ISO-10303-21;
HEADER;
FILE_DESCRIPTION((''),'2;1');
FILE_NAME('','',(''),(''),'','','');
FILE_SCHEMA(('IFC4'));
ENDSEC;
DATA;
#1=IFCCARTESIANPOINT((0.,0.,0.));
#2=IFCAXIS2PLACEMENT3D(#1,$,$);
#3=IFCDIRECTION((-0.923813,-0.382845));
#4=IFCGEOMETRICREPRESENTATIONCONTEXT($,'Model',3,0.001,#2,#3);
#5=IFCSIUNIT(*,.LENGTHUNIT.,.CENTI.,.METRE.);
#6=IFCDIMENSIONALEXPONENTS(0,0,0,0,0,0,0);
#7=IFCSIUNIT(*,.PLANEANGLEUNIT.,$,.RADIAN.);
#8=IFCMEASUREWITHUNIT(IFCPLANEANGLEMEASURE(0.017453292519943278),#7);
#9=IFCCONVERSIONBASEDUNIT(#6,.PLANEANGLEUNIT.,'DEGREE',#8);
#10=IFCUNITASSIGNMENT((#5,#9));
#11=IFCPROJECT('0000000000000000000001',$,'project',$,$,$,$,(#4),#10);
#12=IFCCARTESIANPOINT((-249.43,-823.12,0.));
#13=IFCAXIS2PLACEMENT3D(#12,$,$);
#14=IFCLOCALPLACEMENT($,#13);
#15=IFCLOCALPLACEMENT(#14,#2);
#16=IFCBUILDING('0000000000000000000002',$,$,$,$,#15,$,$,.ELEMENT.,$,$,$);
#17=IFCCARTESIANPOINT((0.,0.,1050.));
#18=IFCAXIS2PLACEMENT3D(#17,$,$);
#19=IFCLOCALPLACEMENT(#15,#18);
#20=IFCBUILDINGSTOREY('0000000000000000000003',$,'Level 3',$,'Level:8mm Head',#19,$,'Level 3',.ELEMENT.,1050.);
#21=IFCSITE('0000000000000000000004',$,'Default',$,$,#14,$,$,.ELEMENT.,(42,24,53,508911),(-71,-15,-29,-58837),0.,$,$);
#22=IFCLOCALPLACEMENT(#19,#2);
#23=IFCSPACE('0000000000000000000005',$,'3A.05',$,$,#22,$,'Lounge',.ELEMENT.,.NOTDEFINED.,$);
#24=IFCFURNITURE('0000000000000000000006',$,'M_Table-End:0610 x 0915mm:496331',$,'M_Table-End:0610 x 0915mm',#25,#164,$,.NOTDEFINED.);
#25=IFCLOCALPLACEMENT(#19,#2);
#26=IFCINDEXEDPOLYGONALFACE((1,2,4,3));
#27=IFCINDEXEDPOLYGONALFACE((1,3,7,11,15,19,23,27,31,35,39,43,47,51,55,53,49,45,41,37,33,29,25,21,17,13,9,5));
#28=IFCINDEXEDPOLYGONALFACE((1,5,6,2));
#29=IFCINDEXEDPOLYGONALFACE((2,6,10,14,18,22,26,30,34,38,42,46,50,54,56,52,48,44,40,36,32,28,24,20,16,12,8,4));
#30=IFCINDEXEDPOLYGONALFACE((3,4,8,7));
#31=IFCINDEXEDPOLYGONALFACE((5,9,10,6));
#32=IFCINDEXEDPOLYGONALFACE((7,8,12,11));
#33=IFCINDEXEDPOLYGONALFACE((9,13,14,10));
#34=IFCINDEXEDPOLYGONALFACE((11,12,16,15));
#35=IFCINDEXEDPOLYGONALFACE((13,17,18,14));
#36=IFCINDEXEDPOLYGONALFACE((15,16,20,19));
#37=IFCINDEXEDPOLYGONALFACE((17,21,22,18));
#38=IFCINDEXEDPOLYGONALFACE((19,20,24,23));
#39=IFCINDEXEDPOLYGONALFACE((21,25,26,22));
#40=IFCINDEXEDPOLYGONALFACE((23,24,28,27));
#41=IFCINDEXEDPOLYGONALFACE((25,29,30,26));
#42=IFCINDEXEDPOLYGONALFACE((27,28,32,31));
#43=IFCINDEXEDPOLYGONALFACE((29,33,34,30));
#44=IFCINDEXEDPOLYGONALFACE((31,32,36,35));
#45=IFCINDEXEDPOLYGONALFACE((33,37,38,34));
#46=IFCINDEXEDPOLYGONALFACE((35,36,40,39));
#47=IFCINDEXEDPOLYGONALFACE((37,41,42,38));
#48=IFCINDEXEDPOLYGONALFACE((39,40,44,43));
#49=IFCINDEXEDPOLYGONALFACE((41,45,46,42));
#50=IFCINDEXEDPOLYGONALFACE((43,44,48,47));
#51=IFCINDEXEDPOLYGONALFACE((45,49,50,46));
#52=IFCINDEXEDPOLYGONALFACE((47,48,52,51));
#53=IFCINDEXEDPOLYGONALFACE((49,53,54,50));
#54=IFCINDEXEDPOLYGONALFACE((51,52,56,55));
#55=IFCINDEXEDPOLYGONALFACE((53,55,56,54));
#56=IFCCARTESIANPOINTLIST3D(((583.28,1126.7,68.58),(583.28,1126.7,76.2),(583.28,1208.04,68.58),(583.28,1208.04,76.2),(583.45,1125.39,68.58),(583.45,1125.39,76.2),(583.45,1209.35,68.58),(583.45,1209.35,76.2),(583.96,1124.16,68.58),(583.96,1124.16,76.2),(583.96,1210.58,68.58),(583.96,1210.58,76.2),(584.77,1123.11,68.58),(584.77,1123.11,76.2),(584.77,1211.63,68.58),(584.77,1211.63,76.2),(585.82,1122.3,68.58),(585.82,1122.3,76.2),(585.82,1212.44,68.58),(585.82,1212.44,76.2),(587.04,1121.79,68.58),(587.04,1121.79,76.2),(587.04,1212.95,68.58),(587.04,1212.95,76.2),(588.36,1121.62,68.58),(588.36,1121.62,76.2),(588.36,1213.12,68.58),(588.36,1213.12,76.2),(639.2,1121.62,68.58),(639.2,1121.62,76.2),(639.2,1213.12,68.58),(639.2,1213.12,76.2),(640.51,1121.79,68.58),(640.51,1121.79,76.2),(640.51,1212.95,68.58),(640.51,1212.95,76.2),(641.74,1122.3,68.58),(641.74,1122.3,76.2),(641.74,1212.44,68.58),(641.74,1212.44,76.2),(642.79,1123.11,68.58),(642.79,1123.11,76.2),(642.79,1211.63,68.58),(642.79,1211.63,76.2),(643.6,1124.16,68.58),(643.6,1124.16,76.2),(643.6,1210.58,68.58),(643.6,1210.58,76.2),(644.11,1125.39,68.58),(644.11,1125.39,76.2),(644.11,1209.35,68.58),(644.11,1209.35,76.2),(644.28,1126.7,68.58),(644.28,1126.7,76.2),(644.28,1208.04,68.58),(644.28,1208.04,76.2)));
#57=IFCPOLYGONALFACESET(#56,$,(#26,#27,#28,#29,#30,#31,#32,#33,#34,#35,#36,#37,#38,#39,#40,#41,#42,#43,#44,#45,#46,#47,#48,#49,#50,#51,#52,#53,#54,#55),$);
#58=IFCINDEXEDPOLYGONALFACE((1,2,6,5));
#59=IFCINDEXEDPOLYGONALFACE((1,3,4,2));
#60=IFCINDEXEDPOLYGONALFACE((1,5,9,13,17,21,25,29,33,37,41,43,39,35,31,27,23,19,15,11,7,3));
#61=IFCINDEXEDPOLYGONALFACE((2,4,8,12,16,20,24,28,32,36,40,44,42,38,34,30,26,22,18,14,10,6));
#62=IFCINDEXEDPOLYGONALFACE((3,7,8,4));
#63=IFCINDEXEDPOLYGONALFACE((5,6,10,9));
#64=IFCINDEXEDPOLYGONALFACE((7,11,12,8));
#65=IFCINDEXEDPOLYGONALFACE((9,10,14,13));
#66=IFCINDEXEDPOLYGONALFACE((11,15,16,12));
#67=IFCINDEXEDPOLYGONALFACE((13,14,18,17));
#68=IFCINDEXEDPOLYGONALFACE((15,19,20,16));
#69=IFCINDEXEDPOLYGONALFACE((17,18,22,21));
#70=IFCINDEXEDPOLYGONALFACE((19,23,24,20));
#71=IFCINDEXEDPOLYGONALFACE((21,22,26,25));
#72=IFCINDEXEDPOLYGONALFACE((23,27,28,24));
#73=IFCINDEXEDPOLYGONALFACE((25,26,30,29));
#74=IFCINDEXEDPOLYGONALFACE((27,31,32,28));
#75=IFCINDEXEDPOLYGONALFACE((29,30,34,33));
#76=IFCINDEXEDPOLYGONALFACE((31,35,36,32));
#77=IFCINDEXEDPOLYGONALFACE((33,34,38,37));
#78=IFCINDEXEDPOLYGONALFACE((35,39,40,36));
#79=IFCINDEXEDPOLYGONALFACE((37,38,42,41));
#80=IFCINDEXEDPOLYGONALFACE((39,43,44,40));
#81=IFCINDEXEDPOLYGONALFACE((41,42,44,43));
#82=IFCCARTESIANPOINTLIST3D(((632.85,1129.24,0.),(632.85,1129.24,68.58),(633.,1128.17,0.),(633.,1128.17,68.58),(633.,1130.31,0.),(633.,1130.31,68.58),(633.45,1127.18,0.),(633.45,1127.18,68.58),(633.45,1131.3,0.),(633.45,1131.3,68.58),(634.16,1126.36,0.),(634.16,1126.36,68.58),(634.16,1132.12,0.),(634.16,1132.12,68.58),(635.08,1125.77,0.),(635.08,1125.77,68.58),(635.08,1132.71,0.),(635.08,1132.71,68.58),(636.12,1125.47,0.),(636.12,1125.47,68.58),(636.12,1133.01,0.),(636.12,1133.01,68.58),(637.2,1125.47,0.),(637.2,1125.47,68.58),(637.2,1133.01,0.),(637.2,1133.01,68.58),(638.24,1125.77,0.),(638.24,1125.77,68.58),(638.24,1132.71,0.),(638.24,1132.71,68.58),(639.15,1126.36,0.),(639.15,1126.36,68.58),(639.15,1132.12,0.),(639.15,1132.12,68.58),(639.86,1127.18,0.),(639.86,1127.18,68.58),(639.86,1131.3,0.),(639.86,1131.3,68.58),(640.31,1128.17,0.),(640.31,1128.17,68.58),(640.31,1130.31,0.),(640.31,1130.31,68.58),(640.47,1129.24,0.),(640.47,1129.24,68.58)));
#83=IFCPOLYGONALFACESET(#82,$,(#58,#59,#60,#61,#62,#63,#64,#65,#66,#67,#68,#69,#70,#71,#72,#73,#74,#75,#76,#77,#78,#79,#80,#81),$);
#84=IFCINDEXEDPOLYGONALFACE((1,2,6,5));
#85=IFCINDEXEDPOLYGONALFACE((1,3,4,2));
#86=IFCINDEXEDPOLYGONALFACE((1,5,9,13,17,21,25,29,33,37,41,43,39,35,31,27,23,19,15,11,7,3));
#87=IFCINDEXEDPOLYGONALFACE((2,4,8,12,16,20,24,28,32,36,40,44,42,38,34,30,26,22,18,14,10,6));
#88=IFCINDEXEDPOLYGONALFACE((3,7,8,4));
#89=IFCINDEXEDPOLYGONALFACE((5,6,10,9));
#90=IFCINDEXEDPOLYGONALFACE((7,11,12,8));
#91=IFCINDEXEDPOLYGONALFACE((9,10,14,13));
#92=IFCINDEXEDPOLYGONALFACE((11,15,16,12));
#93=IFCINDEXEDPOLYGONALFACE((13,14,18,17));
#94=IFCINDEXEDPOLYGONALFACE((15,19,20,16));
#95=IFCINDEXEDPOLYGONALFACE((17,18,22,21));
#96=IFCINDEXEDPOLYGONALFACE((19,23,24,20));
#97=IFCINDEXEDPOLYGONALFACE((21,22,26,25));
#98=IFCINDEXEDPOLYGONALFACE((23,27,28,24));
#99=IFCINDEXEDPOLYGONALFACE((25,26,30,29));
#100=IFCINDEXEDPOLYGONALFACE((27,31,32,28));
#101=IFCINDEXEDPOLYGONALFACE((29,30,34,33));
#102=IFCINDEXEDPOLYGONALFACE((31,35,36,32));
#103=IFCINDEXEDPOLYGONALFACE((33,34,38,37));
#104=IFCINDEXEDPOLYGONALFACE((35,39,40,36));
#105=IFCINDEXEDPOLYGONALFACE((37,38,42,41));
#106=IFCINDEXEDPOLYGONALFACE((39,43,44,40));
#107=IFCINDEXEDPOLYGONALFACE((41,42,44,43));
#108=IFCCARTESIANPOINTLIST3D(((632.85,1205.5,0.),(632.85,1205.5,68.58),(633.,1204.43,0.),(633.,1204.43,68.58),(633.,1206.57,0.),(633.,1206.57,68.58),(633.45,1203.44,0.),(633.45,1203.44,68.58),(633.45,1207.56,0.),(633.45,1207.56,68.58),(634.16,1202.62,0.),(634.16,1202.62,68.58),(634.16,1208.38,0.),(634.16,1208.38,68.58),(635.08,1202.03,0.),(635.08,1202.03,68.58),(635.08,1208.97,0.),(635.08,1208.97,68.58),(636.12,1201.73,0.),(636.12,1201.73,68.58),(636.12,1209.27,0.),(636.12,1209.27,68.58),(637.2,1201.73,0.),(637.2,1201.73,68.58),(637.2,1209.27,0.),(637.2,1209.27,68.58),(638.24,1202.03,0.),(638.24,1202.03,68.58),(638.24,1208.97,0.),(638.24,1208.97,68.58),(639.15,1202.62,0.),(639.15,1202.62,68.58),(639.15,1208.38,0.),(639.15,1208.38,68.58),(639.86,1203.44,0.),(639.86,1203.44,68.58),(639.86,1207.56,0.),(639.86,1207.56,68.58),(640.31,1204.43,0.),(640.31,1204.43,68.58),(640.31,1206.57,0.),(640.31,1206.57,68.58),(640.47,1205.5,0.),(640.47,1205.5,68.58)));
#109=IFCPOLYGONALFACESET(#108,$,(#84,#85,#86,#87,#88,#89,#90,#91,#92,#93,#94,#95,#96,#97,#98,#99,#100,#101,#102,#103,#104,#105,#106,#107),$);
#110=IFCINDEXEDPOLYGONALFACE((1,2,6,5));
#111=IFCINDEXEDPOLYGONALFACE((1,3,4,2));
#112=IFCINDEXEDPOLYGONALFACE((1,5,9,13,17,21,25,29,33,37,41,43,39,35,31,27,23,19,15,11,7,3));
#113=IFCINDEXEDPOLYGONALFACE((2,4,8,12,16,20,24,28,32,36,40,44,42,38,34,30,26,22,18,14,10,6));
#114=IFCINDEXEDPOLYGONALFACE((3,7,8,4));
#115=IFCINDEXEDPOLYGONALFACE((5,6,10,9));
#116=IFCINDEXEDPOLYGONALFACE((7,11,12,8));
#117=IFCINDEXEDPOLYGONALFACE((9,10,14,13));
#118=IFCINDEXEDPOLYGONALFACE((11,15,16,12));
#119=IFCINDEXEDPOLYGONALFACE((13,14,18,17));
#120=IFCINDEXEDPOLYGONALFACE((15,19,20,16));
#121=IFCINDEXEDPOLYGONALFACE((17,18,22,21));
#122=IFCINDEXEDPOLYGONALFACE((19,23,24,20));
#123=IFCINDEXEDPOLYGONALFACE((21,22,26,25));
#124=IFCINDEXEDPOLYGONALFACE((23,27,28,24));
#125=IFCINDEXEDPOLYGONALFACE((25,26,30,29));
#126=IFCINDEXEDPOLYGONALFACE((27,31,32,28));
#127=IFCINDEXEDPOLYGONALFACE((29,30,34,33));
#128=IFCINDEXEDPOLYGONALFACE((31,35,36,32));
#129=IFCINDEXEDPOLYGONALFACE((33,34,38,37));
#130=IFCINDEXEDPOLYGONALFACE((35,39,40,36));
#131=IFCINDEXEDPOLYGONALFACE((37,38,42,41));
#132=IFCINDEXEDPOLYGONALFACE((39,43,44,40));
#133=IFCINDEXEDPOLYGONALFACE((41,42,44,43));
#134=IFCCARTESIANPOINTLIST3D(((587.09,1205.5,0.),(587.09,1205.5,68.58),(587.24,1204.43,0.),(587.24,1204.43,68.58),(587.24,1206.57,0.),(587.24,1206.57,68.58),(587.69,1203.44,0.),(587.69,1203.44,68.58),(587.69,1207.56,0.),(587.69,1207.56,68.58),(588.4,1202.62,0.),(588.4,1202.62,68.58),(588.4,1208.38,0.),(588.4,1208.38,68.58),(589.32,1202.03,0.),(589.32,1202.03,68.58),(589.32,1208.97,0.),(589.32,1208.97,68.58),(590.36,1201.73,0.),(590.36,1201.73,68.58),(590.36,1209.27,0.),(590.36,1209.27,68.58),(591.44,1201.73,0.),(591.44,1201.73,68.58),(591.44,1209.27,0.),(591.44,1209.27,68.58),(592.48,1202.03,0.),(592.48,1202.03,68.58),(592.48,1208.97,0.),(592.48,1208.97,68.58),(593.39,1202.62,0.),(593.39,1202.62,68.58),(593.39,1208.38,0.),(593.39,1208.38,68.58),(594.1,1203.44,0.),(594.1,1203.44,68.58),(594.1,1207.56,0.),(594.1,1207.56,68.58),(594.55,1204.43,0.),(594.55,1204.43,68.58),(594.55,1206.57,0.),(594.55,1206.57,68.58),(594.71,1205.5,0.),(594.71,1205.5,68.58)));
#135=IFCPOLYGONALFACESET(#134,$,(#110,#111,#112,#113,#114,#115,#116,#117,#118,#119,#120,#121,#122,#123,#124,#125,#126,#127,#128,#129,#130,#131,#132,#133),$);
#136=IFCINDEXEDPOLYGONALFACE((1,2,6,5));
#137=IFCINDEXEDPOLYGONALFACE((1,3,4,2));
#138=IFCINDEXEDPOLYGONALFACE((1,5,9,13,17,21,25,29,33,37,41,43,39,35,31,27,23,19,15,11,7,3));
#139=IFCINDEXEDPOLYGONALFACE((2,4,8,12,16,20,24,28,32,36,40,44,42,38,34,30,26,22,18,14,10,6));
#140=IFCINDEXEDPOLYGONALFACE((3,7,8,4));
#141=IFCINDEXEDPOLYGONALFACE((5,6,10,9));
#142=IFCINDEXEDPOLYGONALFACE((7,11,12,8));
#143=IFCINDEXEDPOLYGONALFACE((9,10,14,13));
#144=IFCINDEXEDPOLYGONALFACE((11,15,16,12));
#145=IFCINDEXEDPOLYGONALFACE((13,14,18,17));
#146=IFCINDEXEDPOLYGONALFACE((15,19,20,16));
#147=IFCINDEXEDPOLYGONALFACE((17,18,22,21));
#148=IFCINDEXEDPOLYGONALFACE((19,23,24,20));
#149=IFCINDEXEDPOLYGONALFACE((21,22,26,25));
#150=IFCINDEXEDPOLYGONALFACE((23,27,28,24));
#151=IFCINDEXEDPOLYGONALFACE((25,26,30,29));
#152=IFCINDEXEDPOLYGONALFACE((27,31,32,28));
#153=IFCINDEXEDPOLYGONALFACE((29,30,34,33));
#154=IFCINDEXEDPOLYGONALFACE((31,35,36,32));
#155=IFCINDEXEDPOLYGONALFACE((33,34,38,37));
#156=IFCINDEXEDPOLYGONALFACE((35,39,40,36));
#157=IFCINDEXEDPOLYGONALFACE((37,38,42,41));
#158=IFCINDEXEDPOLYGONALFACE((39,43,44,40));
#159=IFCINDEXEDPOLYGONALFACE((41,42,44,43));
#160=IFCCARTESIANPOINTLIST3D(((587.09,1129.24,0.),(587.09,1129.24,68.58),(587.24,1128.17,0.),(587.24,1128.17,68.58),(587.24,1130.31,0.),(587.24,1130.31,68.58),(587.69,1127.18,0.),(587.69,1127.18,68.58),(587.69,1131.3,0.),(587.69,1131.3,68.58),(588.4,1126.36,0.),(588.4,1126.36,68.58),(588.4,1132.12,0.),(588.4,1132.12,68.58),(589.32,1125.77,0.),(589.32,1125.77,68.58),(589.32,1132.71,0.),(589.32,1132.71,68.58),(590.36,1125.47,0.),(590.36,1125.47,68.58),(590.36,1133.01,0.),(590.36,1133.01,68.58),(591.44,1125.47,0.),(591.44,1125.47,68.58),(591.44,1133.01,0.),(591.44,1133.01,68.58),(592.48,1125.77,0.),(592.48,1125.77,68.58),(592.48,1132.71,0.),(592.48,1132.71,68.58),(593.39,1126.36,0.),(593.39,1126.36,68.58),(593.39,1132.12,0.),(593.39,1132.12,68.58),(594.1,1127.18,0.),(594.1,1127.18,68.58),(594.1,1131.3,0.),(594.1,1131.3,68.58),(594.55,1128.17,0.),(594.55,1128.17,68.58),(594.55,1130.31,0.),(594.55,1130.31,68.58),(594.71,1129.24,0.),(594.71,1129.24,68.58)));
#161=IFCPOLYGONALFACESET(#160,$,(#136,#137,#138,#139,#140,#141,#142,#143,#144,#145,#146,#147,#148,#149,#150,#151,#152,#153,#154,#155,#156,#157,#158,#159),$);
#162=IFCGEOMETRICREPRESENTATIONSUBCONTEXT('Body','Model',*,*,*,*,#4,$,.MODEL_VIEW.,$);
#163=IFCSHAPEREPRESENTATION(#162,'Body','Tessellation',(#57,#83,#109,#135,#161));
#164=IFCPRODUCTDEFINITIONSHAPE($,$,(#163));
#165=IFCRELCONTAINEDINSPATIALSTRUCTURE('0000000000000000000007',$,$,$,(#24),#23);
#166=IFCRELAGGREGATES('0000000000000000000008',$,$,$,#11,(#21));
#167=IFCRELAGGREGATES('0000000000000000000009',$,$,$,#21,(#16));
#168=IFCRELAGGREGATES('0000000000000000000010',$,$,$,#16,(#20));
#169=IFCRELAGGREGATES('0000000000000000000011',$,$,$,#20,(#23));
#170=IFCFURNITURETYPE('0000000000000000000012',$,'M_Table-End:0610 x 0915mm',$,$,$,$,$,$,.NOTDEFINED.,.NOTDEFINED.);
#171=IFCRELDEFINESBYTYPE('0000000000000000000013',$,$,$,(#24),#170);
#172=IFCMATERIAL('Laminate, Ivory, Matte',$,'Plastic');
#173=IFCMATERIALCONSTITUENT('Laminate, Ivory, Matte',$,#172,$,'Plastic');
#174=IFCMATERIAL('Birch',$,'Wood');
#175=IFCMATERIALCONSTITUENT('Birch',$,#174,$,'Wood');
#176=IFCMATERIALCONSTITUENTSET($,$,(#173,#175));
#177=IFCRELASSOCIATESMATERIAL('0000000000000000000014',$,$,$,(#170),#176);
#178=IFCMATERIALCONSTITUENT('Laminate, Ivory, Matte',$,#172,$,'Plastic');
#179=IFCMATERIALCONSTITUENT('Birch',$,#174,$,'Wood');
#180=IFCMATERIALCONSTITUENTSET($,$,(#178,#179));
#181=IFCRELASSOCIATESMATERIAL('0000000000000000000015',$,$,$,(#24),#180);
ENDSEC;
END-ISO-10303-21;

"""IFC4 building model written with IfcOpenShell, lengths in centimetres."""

from ifc_helpers import new_model, entity, si_unit, converted_unit, direction, frame, origin, place, context, subcontext, project, spatial, line, arc, indexed_curve, outline, extrude, source, transform, mapped, material, constituent, constituent_set, type_object, type_shapes, element, save


model = new_model("IFC4")

# Units and contexts
model_context = context("Model", 3, precision=0.001, world=origin(), true_north=direction((-0.923813, -0.382845)))
body_context = subcontext(model_context, "Body", "Model", "MODEL_VIEW")
ifc_project = project(units=[si_unit("LENGTHUNIT", "METRE", prefix="CENTI"), converted_unit("PLANEANGLEUNIT", "DEGREE", entity("IfcPlaneAngleMeasure", 0.017453292519943278), si_unit("PLANEANGLEUNIT", "RADIAN"), dimensions=[0, 0, 0, 0, 0, 0, 0])], contexts=[model_context])

# Site, building, storey
site_placement = place(None, frame((-249.43, -823.12, 0.0)))
site = spatial("IfcSite", under=ifc_project, at=site_placement, Name="Default", CompositionType="ELEMENT", RefLatitude=(42, 24, 53, 508911), RefLongitude=(-71, -15, -29, -58837), RefElevation=0.0)
building_placement = place(site_placement, origin())
building = spatial("IfcBuilding", under=site, at=building_placement, CompositionType="ELEMENT")
storey_placement = place(building_placement, frame((0.0, 0.0, 1050.0)))
storey = spatial("IfcBuildingStorey", under=building, at=storey_placement, Name="Level 3", ObjectType="Level:8mm Head", LongName="Level 3", CompositionType="ELEMENT", Elevation=1050.0)

# Shared definitions
space_1_placement = place(storey_placement, origin())
space_1 = spatial("IfcSpace", under=storey, at=space_1_placement, Name="3A.05", LongName="Lounge", CompositionType="ELEMENT", PredefinedType="NOTDEFINED")

# Furniture
ifc_material_1 = material(Name="Laminate, Ivory, Matte", Category="Plastic")
ifc_constituent_1 = constituent(ifc_material_1, Name="Laminate, Ivory, Matte", Category="Plastic")
ifc_material_2 = material(Name="Birch", Category="Wood")
ifc_constituent_2 = constituent(ifc_material_2, Name="Birch", Category="Wood")
ifc_constituent_set_1 = constituent_set(constituents=[ifc_constituent_1, ifc_constituent_2])
ifc_constituent_3 = constituent(ifc_material_1, Name="Laminate, Ivory, Matte", Category="Plastic")
ifc_constituent_4 = constituent(ifc_material_2, Name="Birch", Category="Wood")
ifc_constituent_set_2 = constituent_set(constituents=[ifc_constituent_3, ifc_constituent_4])
furniture_type_1 = type_object("IfcFurnitureType", Name="M_Table-End:0610 x 0915mm", AssemblyPlace="NOTDEFINED", PredefinedType="NOTDEFINED", material=ifc_constituent_set_2)
shared_shape_1 = source(origin(), body_context, "Body", "SweptSolid", [
    extrude(outline(indexed_curve([(25.42, -45.75), (29.01, -44.26), (30.5, -40.67), (30.5, 40.67), (29.01, 44.26), (25.42, 45.75), (-25.42, 45.75), (-29.01, 44.26), (-30.5, 40.67), (-30.5, -40.67), (-29.01, -44.26), (-25.42, -45.75)], segments=[arc(1, 2, 3), line(3, 4), arc(4, 5, 6), line(6, 7), arc(7, 8, 9), line(9, 10), arc(10, 11, 12), line(12, 1)], self_intersect=False)), frame((30.87, 15.24, -381.42)), (0.0, 0.0, 1.0), 7.62),
    extrude(outline(indexed_curve([(-3.81, 0.0), (0.0, -3.81), (3.81, 0.0), (0.0, 3.81)], segments=[arc(1, 2, 3), arc(3, 4, 1)], self_intersect=False)), frame((53.75, -22.89, -450.0)), (0.0, 0.0, 1.0), 68.58),
    extrude(outline(indexed_curve([(-3.81, 0.0), (0.0, -3.81), (3.81, 0.0), (0.0, 3.81)], segments=[arc(1, 2, 3), arc(3, 4, 1)], self_intersect=False)), frame((53.75, 53.37, -450.0)), (0.0, 0.0, 1.0), 68.58),
    extrude(outline(indexed_curve([(-3.81, 0.0), (0.0, -3.81), (3.81, 0.0), (0.0, 3.81)], segments=[arc(1, 2, 3), arc(3, 4, 1)], self_intersect=False)), frame((7.99, 53.37, -450.0)), (0.0, 0.0, 1.0), 68.58),
    extrude(outline(indexed_curve([(-3.81, 0.0), (0.0, -3.81), (3.81, 0.0), (0.0, 3.81)], segments=[arc(1, 2, 3), arc(3, 4, 1)], self_intersect=False)), frame((7.99, -22.89, -450.0)), (0.0, 0.0, 1.0), 68.58),
])
type_shapes(furniture_type_1, [shared_shape_1])
furniture_1_placement = place(space_1_placement, frame((582.9, 1152.13, 450.0)))
element("IfcFurniture", 1, at=furniture_1_placement, inside=space_1, type_object=furniture_type_1, material=ifc_constituent_set_1, Name="M_Table-End:0610 x 0915mm:496331", ObjectType="M_Table-End:0610 x 0915mm", PredefinedType="NOTDEFINED", context=body_context, shape_type="MappedRepresentation", body=[
    mapped(shared_shape_1, transform((0.0, 0.0, 0.0), scale=1.0)),
])

save(model, "model.ifc")
